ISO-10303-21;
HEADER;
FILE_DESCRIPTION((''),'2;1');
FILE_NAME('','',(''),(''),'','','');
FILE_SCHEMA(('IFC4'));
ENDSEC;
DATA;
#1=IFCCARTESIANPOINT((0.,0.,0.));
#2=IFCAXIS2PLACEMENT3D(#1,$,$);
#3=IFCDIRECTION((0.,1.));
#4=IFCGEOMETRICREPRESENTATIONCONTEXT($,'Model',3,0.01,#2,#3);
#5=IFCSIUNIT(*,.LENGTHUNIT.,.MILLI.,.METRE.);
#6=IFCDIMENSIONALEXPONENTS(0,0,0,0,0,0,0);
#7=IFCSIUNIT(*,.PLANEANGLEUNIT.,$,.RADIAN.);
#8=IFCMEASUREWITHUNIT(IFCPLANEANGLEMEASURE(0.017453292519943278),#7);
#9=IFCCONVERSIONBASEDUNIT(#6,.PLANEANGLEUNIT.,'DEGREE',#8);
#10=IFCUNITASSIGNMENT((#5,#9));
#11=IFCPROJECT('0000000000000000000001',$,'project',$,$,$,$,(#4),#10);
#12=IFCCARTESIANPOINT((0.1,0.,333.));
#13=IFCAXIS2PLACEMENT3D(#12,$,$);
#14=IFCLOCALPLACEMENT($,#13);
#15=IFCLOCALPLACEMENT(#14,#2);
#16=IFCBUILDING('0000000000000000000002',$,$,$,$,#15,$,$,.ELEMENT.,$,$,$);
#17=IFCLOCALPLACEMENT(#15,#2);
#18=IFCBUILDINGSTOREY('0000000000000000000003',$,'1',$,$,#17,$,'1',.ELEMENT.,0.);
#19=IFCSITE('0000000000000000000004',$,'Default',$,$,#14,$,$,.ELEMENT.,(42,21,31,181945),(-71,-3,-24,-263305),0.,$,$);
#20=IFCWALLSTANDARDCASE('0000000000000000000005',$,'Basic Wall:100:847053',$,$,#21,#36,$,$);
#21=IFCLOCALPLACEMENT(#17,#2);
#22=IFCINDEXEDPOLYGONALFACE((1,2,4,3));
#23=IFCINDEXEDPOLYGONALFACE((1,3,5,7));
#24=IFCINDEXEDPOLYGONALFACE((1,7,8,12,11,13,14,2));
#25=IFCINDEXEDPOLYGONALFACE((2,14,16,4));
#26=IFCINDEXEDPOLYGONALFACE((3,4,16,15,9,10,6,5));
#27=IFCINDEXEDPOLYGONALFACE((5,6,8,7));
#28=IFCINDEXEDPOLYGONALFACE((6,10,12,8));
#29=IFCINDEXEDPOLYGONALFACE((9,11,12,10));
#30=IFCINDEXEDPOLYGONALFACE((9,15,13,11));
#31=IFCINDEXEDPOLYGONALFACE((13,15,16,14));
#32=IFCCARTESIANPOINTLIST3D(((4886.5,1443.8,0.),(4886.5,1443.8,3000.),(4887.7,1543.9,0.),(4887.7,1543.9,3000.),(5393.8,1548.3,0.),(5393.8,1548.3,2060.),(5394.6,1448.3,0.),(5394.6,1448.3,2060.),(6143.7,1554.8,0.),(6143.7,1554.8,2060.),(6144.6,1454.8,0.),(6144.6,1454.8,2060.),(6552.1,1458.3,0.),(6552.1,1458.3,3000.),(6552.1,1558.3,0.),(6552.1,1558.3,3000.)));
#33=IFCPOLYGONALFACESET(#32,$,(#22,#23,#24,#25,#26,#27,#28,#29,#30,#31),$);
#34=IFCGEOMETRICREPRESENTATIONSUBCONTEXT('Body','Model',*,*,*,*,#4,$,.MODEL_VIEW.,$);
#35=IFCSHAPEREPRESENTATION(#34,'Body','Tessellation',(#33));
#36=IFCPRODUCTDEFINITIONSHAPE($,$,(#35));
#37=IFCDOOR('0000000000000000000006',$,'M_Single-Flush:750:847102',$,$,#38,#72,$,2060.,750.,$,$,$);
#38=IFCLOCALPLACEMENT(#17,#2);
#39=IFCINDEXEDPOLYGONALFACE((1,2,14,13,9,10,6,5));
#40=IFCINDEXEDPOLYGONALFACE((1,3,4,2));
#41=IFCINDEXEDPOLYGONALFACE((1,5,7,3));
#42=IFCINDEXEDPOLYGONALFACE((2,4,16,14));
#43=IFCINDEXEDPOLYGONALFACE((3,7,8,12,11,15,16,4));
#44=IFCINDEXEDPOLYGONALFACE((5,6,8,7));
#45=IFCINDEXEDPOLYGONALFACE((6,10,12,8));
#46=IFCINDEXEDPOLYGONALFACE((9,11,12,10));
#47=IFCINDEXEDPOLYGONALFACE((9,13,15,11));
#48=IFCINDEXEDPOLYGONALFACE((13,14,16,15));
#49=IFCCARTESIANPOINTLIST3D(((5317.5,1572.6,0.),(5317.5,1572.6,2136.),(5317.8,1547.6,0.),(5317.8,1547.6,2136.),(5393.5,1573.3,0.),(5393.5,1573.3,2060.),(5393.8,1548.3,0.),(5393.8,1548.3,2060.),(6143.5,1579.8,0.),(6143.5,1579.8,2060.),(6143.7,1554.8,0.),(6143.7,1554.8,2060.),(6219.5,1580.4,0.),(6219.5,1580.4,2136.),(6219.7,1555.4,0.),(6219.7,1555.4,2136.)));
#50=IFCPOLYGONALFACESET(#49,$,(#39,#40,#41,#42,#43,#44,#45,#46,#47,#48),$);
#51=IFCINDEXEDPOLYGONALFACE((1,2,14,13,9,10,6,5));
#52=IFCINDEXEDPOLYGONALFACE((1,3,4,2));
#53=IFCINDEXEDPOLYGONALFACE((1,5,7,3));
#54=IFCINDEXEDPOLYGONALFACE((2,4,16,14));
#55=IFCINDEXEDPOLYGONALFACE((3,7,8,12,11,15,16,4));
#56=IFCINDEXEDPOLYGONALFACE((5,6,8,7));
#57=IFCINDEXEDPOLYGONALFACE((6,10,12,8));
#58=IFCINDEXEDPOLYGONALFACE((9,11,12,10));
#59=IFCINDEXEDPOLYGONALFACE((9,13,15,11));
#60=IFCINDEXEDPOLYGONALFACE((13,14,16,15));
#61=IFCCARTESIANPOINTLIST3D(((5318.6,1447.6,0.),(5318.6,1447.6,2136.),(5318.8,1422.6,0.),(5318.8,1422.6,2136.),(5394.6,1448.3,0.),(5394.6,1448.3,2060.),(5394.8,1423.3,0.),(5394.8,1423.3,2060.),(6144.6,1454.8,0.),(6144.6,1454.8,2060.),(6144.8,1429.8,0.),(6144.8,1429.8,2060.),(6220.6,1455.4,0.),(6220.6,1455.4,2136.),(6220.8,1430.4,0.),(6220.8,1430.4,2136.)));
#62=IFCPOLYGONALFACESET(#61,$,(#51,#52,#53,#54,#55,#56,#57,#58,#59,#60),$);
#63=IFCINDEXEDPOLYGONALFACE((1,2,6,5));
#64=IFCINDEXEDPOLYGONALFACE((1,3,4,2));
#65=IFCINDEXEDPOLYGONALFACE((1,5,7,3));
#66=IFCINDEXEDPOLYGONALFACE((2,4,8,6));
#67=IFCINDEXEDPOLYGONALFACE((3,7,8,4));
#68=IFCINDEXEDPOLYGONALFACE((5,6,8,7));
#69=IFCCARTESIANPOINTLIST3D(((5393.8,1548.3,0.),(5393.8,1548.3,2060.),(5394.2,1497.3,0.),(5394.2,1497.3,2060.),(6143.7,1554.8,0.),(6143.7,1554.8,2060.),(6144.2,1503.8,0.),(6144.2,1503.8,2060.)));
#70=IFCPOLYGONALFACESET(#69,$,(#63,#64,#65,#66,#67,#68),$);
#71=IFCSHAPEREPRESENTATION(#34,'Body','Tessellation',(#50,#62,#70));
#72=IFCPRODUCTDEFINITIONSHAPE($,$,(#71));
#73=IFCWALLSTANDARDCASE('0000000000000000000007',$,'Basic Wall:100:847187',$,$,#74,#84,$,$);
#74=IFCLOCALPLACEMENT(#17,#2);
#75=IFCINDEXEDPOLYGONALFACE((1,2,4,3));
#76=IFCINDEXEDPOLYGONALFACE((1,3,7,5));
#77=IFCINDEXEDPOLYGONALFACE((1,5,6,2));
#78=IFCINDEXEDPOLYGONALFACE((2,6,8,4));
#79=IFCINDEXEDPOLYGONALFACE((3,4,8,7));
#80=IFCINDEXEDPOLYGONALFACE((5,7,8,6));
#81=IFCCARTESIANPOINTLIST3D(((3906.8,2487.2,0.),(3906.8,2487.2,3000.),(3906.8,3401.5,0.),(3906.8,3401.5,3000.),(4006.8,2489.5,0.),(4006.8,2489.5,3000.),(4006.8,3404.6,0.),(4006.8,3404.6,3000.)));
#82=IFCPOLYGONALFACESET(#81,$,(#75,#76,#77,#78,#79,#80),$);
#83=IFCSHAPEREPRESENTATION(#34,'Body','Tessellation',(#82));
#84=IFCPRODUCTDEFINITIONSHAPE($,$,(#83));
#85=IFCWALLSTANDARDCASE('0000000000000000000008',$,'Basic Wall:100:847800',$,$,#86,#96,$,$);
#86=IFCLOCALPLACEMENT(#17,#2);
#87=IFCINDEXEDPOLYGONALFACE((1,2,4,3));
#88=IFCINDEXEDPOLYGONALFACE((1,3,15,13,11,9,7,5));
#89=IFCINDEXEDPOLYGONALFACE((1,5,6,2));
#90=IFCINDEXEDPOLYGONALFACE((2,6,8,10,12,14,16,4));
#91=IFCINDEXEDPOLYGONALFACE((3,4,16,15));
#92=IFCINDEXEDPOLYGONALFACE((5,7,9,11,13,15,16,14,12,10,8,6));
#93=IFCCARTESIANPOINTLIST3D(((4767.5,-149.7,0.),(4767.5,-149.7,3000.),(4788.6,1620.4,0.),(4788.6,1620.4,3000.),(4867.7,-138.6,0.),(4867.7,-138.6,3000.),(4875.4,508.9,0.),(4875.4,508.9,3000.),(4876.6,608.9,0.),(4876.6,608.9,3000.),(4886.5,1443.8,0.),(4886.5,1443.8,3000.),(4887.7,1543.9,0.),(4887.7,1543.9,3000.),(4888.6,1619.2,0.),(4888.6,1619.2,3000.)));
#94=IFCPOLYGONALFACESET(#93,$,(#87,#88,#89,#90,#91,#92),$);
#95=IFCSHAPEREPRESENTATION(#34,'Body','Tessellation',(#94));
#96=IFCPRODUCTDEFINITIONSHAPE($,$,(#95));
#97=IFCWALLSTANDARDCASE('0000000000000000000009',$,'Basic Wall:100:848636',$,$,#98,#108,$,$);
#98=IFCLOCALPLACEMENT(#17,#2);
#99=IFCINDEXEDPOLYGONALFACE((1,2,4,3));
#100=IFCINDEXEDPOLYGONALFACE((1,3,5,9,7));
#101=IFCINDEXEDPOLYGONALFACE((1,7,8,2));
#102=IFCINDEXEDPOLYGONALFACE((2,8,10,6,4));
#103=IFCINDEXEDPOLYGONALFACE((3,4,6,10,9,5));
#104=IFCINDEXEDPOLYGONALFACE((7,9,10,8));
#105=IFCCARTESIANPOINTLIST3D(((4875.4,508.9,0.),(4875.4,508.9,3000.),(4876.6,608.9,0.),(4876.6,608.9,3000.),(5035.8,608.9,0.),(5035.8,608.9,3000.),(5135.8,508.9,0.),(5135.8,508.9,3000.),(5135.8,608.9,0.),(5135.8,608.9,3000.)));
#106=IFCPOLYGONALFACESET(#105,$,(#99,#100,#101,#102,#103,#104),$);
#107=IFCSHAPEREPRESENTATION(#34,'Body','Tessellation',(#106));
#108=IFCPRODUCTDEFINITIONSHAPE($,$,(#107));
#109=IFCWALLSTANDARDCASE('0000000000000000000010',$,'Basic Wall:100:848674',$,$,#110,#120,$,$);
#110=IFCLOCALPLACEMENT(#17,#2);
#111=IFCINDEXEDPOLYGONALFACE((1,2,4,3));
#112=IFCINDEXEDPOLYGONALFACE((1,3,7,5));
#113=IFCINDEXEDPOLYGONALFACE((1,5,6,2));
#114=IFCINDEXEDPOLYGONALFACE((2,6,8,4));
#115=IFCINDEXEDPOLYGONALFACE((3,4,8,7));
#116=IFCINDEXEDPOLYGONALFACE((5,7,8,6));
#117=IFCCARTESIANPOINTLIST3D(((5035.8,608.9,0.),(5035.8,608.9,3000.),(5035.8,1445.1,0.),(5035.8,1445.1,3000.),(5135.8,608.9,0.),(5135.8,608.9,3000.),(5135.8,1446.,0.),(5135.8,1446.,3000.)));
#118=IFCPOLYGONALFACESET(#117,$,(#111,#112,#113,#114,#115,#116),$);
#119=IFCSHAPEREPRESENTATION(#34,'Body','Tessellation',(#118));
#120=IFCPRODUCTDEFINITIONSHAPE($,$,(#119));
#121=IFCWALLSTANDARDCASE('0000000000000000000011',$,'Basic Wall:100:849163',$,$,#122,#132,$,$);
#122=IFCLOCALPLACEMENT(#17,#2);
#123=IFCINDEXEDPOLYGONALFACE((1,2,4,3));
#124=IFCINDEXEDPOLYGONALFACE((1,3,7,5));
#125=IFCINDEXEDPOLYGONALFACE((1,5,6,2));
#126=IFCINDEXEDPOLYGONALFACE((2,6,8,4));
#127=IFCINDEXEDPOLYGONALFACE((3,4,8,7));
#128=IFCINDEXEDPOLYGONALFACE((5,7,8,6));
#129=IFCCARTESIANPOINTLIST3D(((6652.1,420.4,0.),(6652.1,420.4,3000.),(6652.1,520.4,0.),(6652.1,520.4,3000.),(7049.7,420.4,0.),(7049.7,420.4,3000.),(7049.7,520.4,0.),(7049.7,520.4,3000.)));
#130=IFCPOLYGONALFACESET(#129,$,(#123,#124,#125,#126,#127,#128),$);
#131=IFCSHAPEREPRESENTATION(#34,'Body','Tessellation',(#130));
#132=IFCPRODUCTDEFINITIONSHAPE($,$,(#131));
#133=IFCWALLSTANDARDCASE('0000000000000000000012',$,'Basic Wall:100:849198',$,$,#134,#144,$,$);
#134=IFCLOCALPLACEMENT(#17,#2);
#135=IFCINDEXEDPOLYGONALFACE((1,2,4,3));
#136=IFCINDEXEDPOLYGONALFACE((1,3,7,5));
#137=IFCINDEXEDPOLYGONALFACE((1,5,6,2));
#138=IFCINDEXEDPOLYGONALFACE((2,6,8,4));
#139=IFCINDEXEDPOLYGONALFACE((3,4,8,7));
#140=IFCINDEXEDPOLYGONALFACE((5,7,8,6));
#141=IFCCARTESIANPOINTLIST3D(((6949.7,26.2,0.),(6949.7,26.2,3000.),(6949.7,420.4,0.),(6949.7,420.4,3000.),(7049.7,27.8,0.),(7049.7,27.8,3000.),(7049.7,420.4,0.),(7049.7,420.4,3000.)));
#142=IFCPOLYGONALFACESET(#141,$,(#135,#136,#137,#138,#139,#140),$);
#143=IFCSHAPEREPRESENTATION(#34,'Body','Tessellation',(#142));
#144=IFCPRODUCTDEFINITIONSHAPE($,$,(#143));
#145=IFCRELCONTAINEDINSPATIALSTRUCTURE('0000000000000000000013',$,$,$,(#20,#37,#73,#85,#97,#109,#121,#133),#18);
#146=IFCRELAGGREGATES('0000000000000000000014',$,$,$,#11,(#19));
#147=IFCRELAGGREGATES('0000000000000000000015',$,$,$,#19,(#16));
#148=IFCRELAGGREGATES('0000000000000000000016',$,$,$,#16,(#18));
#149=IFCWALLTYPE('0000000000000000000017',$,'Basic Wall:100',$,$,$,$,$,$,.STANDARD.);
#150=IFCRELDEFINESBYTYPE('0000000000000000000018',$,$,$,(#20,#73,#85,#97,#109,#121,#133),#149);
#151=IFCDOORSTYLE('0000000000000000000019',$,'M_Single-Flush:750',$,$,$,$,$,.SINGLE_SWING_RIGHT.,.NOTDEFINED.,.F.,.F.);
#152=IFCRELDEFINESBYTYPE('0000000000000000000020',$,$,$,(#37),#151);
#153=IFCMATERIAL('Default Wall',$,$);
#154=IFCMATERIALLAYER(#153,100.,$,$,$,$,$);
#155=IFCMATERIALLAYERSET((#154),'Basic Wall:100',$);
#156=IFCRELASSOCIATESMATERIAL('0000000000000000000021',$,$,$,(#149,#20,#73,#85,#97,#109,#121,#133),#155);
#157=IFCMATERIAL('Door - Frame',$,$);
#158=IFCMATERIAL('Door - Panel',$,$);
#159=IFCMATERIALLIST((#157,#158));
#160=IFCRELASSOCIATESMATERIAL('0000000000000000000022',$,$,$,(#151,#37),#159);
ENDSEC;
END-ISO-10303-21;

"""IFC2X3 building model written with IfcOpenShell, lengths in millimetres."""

from ifc_helpers import new_model, entity, si_unit, converted_unit, direction, frame, frame_2d, origin, origin_2d_with_axis, place, context, subcontext, project, spatial, polyline, rectangle, outline, extrude, source, transform, mapped, material, material_list, layer, layer_set, layer_usage, type_object, type_shapes, element, fill, save


model = new_model("IFC2X3")

# Units and contexts
model_context = context("Model", 3, precision=0.01, world=origin(), true_north=direction((0.0, 1.0)))
body_context = subcontext(model_context, "Body", "Model", "MODEL_VIEW")
ifc_project = project(units=[si_unit("LENGTHUNIT", "METRE", prefix="MILLI"), converted_unit("PLANEANGLEUNIT", "DEGREE", entity("IfcPlaneAngleMeasure", 0.017453292519943278), si_unit("PLANEANGLEUNIT", "RADIAN"), dimensions=[0, 0, 0, 0, 0, 0, 0])], contexts=[model_context])

# Site, building, storey
site_placement = place(None, frame((0.1, 0.0, 333.0)))
site = spatial("IfcSite", under=ifc_project, at=site_placement, Name="Default", CompositionType="ELEMENT", RefLatitude=(42, 21, 31, 181945), RefLongitude=(-71, -3, -24, -263305), RefElevation=0.0)
building_placement = place(site_placement, origin())
building = spatial("IfcBuilding", under=site, at=building_placement, CompositionType="ELEMENT")
storey_placement = place(building_placement, origin())
storey = spatial("IfcBuildingStorey", under=building, at=storey_placement, Name="1", LongName="1", CompositionType="ELEMENT", Elevation=0.0)

# Shared definitions
ifc_material_1 = material(Name="Default Wall")

# Shared definitions
ifc_material_2 = material(Name="Door - Frame")
ifc_material_3 = material(Name="Door - Panel")
ifc_material_list_1 = material_list([ifc_material_2, ifc_material_3])

# Shared definitions
ifc_layer_1 = layer(ifc_material_1, 100.0)
ifc_layer_set_1 = layer_set([ifc_layer_1], Name="Basic Wall:100")
wall_type_1 = type_object("IfcWallType", Name="Basic Wall:100", PredefinedType="STANDARD", material=ifc_layer_set_1)

# Wall, opening, door
ifc_layer_usage_1 = layer_usage(ifc_layer_set_1, "AXIS2", "POSITIVE", -50.0)
wall_1_placement = place(storey_placement, frame((4886.1, 1493.8, 0.0), z_axis=(0.0, 0.0, 1.0), x_axis=(0.999962, 0.008695, 0.0)))
wall_1 = element("IfcWallStandardCase", 1, at=wall_1_placement, inside=storey, type_object=wall_type_1, material=ifc_layer_usage_1, Name="Basic Wall:100:847053", context=body_context, shape_type="SweptSolid", body=[
    extrude(outline(polyline([(0.0, -50.0), (149.3, -50.0), (249.3, -50.0), (1665.6, -50.0), (1666.5, 50.0), (2.1, 50.0), (0.0, -50.0)])), origin(), (0.0, 0.0, 1.0), 3000.0),
])
opening_1_placement = place(wall_1_placement, frame((508.1, -50.0, 0.0)))
opening_1 = element("IfcOpeningElement", 2, at=opening_1_placement, cuts=wall_1, ObjectType="Opening", context=body_context, shape_type="SweptSolid", body=[
    extrude(rectangle(XDim=750.0, YDim=2060.0, at=frame_2d((1030.0, 375.0), x_axis=(0.0, 1.0))), frame((0.0, 0.0, 0.0), z_axis=(0.0, 1.0, 0.0), x_axis=(0.0, 0.0, 1.0)), (0.0, 0.0, 1.0), 100.0),
])
door_style_1 = type_object("IfcDoorStyle", Name="M_Single-Flush:750", ConstructionType="NOTDEFINED", OperationType="SINGLE_SWING_RIGHT", ParameterTakesPrecedence=False, Sizeable=False, material=ifc_material_list_1)
shared_shape_1 = source(origin(), body_context, "Body", "SweptSolid", [
    extrude(outline(polyline([(-451.0, -1087.0), (451.0, -1087.0), (451.0, 1049.0), (375.0, 1049.0), (375.0, -1011.0), (-375.0, -1011.0), (-375.0, 1049.0), (-451.0, 1049.0), (-451.0, -1087.0)])), frame((375.0, 100.0, 1049.0), z_axis=(0.0, 1.0, 0.0), x_axis=(1.0, 0.0, 0.0)), (0.0, 0.0, 1.0), 25.0),
    extrude(outline(polyline([(-1087.0, -451.0), (1049.0, -451.0), (1049.0, -375.0), (-1011.0, -375.0), (-1011.0, 375.0), (1049.0, 375.0), (1049.0, 451.0), (-1087.0, 451.0), (-1087.0, -451.0)])), frame((375.0, -25.0, 1049.0), z_axis=(0.0, 1.0, 0.0), x_axis=(0.0, 0.0, -1.0)), (0.0, 0.0, 1.0), 25.0),
    extrude(rectangle(XDim=51.0, YDim=750.0, at=origin_2d_with_axis()), frame((375.0, 74.5, 0.0), z_axis=(0.0, 0.0, 1.0), x_axis=(0.0, 1.0, 0.0)), (0.0, 0.0, 1.0), 2060.0),
])
type_shapes(door_style_1, [shared_shape_1])
door_1_placement = place(opening_1_placement, origin())
door_1 = element("IfcDoor", 3, at=door_1_placement, inside=storey, type_object=door_style_1, material=ifc_material_list_1, Name="M_Single-Flush:750:847102", OverallHeight=2060.0, OverallWidth=750.0, context=body_context, shape_type="MappedRepresentation", body=[
    mapped(shared_shape_1, transform((0.0, 0.0, 0.0), scale=1.0)),
])
fill(opening_1, door_1)

# Walls
ifc_layer_usage_2 = layer_usage(ifc_layer_set_1, "AXIS2", "NEGATIVE", 50.0)
wall_2_placement = place(storey_placement, frame((3956.8, 3404.6, 0.0), z_axis=(0.0, 0.0, 1.0), x_axis=(0.0, -1.0, 0.0)))
element("IfcWallStandardCase", 4, at=wall_2_placement, inside=storey, type_object=wall_type_1, material=ifc_layer_usage_2, Name="Basic Wall:100:847187", context=body_context, shape_type="SweptSolid", body=[
    extrude(outline(polyline([(917.4, -50.0), (915.1, 50.0), (0.0, 50.0), (3.1, -50.0), (917.4, -50.0)])), origin(), (0.0, 0.0, 1.0), 3000.0),
])
ifc_layer_usage_3 = layer_usage(ifc_layer_set_1, "AXIS2", "POSITIVE", -50.0)
wall_3_placement = place(storey_placement, frame((4838.6, 1619.8, 0.0), z_axis=(0.0, 0.0, 1.0), x_axis=(-0.011924, -0.999929, 0.0)))
element("IfcWallStandardCase", 5, at=wall_3_placement, inside=storey, type_object=wall_type_1, material=ifc_layer_usage_3, Name="Basic Wall:100:847800", context=body_context, shape_type="SweptSolid", body=[
    extrude(outline(polyline([(1770.2, -50.0), (1757.9, 50.0), (1110.4, 50.0), (1010.4, 50.0), (175.4, 50.0), (75.4, 50.0), (0.0, 50.0), (0.0, -50.0), (1770.2, -50.0)])), origin(), (0.0, 0.0, 1.0), 3000.0),
])
ifc_layer_usage_4 = layer_usage(ifc_layer_set_1, "AXIS2", "POSITIVE", -50.0)
wall_4_placement = place(storey_placement, frame((5135.8, 558.9, 0.0), z_axis=(0.0, 0.0, 1.0), x_axis=(-1.0, 0.0, 0.0)))
element("IfcWallStandardCase", 6, at=wall_4_placement, inside=storey, type_object=wall_type_1, material=ifc_layer_usage_4, Name="Basic Wall:100:848636", context=body_context, shape_type="SweptSolid", body=[
    extrude(outline(polyline([(259.2, -50.0), (260.4, 50.0), (0.0, 50.0), (0.0, -50.0), (100.0, -50.0), (259.2, -50.0)])), origin(), (0.0, 0.0, 1.0), 3000.0),
])
ifc_layer_usage_5 = layer_usage(ifc_layer_set_1, "AXIS2", "POSITIVE", -50.0)
wall_5_placement = place(storey_placement, frame((5085.8, 1446.0, 0.0), z_axis=(0.0, 0.0, 1.0), x_axis=(0.0, -1.0, 0.0)))
element("IfcWallStandardCase", 7, at=wall_5_placement, inside=storey, type_object=wall_type_1, material=ifc_layer_usage_5, Name="Basic Wall:100:848674", context=body_context, shape_type="SweptSolid", body=[
    extrude(outline(polyline([(837.1, -50.0), (837.1, 50.0), (0.0, 50.0), (0.9, -50.0), (837.1, -50.0)])), origin(), (0.0, 0.0, 1.0), 3000.0),
])
ifc_layer_usage_6 = layer_usage(ifc_layer_set_1, "AXIS2", "NEGATIVE", 50.0)
wall_6_placement = place(storey_placement, frame((7049.7, 470.4, 0.0), z_axis=(0.0, 0.0, 1.0), x_axis=(-1.0, 0.0, 0.0)))
element("IfcWallStandardCase", 8, at=wall_6_placement, inside=storey, type_object=wall_type_1, material=ifc_layer_usage_6, Name="Basic Wall:100:849163", context=body_context, shape_type="SweptSolid", body=[
    extrude(rectangle(XDim=397.6, YDim=100.0, at=frame_2d((198.8, 0.0), x_axis=(-1.0, 0.0))), origin(), (0.0, 0.0, 1.0), 3000.0),
])
ifc_layer_usage_7 = layer_usage(ifc_layer_set_1, "AXIS2", "POSITIVE", -50.0)
wall_7_placement = place(storey_placement, frame((6999.7, 420.4, 0.0), z_axis=(0.0, 0.0, 1.0), x_axis=(0.0, -1.0, 0.0)))
element("IfcWallStandardCase", 9, at=wall_7_placement, inside=storey, type_object=wall_type_1, material=ifc_layer_usage_7, Name="Basic Wall:100:849198", context=body_context, shape_type="SweptSolid", body=[
    extrude(outline(polyline([(394.2, -50.0), (392.6, 50.0), (0.0, 50.0), (0.0, -50.0), (394.2, -50.0)])), origin(), (0.0, 0.0, 1.0), 3000.0),
])

save(model, "model.ifc")
